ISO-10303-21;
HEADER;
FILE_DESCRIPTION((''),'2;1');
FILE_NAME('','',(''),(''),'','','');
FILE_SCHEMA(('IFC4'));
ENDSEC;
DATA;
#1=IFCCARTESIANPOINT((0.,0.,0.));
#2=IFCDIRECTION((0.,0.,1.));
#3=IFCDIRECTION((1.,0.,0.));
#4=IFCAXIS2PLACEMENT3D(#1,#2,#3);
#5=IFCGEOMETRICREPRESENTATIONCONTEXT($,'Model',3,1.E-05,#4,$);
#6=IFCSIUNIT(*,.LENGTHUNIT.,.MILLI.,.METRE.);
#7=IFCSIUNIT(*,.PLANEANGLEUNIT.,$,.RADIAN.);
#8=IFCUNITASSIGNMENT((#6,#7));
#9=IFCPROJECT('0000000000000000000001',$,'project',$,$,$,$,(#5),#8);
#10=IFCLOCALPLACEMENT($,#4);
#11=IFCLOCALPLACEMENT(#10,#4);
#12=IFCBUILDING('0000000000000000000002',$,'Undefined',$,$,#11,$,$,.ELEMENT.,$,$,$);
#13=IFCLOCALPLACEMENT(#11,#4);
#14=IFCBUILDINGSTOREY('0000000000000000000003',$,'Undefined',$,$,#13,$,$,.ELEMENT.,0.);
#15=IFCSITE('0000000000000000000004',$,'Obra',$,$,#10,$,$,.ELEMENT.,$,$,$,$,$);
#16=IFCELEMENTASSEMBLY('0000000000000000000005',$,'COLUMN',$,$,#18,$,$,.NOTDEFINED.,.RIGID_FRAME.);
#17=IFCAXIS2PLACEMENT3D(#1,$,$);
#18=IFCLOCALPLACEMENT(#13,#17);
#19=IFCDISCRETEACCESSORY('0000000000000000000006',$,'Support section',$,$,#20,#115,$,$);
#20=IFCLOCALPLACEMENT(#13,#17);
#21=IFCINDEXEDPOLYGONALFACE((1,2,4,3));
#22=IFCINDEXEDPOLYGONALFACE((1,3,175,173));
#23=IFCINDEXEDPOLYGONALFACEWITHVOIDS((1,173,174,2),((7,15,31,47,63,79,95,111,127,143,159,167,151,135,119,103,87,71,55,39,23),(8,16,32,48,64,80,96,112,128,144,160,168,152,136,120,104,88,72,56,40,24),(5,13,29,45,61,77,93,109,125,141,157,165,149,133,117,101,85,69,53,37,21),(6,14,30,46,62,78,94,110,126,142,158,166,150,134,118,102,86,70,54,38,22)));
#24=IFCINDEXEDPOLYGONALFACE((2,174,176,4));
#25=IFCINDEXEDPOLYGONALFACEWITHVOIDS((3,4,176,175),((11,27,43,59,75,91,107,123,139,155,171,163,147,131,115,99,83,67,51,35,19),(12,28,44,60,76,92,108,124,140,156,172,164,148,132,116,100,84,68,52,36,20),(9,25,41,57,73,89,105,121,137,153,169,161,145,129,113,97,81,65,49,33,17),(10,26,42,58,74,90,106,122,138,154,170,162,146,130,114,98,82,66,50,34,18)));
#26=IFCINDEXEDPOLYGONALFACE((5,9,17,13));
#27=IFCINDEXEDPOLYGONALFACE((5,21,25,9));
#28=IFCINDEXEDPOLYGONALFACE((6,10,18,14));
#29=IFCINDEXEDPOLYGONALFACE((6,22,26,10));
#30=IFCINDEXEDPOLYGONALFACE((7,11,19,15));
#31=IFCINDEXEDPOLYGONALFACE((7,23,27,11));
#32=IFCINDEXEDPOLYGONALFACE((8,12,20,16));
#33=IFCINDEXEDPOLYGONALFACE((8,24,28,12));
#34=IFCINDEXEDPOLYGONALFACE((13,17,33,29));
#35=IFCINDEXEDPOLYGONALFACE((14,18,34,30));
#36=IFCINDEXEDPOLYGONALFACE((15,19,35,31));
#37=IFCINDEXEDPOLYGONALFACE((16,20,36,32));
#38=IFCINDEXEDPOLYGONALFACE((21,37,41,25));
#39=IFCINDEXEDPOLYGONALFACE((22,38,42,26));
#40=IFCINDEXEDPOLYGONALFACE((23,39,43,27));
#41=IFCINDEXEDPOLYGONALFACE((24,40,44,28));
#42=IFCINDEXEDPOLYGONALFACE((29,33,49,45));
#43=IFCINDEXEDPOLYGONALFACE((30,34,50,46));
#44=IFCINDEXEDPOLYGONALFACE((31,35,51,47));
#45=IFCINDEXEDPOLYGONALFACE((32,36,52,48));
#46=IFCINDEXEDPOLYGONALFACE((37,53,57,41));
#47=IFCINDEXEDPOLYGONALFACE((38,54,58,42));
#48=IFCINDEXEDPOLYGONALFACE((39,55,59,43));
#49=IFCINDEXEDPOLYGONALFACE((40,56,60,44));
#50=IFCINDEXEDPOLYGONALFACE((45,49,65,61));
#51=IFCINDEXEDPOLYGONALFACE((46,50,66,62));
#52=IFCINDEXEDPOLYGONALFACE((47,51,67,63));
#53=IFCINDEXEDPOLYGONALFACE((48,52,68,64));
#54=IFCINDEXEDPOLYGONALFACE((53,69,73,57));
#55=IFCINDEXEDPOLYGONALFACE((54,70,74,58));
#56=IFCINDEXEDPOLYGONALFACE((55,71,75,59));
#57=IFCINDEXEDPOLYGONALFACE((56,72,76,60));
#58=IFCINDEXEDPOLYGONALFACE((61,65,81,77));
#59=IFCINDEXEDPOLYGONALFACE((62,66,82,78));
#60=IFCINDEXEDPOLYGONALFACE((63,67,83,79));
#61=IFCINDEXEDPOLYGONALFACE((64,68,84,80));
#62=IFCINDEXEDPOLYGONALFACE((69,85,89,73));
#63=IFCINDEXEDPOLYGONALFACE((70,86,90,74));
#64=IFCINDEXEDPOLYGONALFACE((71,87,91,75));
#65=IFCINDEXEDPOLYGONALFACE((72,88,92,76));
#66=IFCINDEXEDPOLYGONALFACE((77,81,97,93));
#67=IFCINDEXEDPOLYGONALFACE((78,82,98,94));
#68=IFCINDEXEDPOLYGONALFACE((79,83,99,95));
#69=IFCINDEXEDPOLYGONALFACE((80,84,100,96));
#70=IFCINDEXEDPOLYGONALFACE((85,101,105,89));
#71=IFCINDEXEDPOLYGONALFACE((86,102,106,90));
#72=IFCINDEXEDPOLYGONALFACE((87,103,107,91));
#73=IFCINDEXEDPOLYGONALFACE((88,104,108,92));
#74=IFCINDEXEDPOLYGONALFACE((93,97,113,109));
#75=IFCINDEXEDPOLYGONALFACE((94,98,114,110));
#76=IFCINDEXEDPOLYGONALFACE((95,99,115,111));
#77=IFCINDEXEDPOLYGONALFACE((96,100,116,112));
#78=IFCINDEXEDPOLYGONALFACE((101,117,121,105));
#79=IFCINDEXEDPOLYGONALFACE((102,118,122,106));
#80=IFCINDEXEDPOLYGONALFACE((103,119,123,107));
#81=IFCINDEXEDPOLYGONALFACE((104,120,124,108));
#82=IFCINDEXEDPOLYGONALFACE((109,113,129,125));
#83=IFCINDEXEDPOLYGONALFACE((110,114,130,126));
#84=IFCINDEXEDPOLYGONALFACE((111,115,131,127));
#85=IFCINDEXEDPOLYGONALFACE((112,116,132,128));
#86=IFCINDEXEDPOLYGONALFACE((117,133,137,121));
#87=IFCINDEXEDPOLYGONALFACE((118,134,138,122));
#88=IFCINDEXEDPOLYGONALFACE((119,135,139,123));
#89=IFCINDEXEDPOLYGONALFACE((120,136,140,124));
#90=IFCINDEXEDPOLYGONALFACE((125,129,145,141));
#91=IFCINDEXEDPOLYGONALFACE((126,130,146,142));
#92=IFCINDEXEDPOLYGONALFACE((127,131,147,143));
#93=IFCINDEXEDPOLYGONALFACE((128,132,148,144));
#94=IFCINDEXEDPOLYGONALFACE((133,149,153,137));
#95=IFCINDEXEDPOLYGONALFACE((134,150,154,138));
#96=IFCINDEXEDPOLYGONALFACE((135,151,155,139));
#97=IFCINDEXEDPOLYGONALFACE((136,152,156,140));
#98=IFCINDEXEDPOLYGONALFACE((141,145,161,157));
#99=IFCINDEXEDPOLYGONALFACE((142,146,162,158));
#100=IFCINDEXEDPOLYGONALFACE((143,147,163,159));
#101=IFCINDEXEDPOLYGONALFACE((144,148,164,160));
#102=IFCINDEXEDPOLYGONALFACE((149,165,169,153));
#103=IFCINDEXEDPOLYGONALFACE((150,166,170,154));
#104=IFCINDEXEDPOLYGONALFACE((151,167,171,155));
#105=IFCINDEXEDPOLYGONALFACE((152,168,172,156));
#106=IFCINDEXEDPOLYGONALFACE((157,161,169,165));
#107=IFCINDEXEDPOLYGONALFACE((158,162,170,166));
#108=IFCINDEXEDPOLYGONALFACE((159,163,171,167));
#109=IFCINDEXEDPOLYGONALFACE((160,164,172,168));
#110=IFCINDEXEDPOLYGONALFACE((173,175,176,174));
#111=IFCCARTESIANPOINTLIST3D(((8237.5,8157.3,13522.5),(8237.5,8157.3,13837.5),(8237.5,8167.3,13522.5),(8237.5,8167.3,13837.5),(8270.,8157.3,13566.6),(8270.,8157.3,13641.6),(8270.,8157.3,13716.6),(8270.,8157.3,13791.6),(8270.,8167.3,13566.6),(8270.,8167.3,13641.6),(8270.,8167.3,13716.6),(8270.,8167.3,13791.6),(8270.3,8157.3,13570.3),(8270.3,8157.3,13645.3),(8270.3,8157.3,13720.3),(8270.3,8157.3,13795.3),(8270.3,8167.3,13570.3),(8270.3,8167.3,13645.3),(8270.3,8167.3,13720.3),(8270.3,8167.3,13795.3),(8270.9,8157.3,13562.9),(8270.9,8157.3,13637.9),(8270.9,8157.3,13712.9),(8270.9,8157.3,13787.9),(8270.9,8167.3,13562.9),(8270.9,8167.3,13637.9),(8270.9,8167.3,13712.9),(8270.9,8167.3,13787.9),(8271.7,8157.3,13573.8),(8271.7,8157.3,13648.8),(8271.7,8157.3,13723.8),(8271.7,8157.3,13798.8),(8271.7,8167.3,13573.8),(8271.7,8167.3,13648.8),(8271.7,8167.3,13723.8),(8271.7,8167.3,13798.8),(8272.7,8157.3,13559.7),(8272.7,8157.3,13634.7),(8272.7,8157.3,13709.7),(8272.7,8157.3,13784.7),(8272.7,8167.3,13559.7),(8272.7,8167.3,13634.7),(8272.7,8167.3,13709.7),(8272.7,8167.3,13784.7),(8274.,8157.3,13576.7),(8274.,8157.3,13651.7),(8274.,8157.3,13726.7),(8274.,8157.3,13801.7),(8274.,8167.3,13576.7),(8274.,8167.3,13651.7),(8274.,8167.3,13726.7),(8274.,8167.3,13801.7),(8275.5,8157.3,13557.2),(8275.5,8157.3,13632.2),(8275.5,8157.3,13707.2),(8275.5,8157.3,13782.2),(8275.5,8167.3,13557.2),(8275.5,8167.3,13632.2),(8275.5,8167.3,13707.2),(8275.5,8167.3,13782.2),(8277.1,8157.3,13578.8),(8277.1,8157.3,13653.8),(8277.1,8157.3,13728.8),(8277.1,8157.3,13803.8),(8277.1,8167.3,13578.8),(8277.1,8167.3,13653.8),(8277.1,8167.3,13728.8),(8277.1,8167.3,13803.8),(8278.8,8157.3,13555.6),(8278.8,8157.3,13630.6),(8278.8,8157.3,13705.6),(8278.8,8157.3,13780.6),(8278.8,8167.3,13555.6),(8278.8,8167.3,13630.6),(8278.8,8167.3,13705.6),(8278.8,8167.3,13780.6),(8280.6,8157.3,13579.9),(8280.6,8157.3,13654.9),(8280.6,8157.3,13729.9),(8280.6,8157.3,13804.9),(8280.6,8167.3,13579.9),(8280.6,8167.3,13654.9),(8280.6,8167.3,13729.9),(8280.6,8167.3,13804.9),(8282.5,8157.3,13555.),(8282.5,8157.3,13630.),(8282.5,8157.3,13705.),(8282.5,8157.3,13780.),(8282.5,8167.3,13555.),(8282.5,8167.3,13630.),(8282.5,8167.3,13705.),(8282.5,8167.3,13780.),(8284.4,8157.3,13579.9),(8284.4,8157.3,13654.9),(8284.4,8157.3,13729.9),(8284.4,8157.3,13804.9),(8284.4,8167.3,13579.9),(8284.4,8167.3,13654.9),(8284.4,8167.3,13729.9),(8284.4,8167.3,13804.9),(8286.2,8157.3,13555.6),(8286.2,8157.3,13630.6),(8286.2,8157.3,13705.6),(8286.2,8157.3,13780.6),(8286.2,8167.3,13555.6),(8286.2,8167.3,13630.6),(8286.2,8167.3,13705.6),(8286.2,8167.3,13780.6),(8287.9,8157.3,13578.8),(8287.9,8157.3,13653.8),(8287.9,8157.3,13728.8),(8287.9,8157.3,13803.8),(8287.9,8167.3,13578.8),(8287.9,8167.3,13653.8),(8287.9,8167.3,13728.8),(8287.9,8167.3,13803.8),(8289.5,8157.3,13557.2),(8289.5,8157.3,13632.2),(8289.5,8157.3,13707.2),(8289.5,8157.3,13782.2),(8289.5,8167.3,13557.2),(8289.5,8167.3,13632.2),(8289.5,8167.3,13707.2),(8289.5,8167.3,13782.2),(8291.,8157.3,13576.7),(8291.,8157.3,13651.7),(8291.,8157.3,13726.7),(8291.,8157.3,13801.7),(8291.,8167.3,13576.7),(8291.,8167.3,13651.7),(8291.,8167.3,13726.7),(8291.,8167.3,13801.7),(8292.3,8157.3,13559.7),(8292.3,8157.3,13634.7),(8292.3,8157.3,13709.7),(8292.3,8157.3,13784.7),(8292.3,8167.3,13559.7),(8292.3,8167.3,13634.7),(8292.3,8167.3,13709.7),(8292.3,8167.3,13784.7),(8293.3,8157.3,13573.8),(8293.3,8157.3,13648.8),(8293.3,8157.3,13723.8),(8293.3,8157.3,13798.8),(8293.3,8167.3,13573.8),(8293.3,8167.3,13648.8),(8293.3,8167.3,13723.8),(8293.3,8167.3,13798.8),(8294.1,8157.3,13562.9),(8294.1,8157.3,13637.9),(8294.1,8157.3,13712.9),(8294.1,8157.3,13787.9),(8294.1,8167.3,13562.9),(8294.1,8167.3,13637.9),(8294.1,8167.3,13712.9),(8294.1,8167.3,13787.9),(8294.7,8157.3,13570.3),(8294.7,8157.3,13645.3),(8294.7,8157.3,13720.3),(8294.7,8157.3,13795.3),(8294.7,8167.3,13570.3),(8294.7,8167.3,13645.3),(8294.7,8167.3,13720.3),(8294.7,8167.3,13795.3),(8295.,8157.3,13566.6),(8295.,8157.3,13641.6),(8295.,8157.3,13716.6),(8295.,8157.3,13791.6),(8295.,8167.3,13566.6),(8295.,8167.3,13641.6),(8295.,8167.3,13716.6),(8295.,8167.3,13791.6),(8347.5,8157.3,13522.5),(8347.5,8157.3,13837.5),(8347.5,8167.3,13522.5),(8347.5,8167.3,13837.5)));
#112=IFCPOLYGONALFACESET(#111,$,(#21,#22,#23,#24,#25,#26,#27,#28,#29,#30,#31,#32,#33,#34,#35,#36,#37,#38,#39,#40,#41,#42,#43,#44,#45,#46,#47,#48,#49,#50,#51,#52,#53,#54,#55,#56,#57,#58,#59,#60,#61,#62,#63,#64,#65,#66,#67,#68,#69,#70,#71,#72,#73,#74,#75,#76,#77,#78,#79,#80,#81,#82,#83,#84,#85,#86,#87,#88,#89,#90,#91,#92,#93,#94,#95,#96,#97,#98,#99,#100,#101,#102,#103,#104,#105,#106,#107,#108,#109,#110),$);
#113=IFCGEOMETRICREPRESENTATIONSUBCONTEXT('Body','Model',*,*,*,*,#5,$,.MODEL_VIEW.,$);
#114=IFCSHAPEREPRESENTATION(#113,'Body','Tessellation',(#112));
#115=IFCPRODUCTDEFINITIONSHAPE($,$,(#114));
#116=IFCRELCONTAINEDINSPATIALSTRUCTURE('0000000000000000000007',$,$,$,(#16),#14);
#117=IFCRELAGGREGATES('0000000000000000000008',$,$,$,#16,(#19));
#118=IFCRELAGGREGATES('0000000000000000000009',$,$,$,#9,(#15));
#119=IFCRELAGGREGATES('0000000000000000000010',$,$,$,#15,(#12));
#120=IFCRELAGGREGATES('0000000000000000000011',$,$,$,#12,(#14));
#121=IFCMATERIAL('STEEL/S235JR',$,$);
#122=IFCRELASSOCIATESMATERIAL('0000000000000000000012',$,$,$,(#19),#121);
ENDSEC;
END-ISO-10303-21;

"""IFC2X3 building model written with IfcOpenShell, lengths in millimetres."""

from ifc_helpers import new_model, si_unit, frame, origin_with_axes, origin_2d_with_axis, place, context, subcontext, project, spatial, rectangle, circle, extrude, source, transform, mapped, material, element, aggregate, save


model = new_model("IFC2X3")

# Units and contexts
model_context = context("Model", 3, precision=1e-05, world=origin_with_axes())
body_context = subcontext(model_context, "Body", "Model", "MODEL_VIEW")
ifc_project = project(units=[si_unit("LENGTHUNIT", "METRE", prefix="MILLI"), si_unit("PLANEANGLEUNIT", "RADIAN")], contexts=[model_context])

# Site, building, storey
site_placement = place(None, origin_with_axes())
site = spatial("IfcSite", under=ifc_project, at=site_placement, Name="Obra", CompositionType="ELEMENT")
building_placement = place(site_placement, origin_with_axes())
building = spatial("IfcBuilding", under=site, at=building_placement, Name="Undefined", CompositionType="ELEMENT")
storey_placement = place(building_placement, origin_with_axes())
storey = spatial("IfcBuildingStorey", under=building, at=storey_placement, Name="Undefined", CompositionType="ELEMENT", Elevation=0.0)

# Element assembly
assembly_1_placement = place(storey_placement, origin_with_axes())
assembly_1 = element("IfcElementAssembly", 1, at=assembly_1_placement, inside=storey, Name="COLUMN", AssemblyPlace="NOTDEFINED", PredefinedType="RIGID_FRAME")
ifc_material_1 = material(Name="STEEL/S235JR")

# Discrete accessory, opening
discrete_accessory_1_placement = place(assembly_1_placement, frame((8292.5, 8162.3, 13522.5), z_axis=(0.0, 0.0, 1.0), x_axis=(1.0, 0.0, 0.0)))
discrete_accessory_1 = element("IfcDiscreteAccessory", 2, at=discrete_accessory_1_placement, material=ifc_material_1, Name="Support section", context=body_context, shape_type="SweptSolid", body=[
    extrude(rectangle(XDim=10.0, YDim=110.0, at=origin_2d_with_axis()), frame((0.0, 0.0, 315.0), z_axis=(0.0, 0.0, -1.0), x_axis=(0.0, 1.0, 0.0)), (0.0, 0.0, 1.0), 315.0),
])
shared_shape_1 = source(origin_with_axes(), body_context, "Body", "SweptSolid", [
    extrude(circle(Radius=12.5, at=origin_2d_with_axis()), frame((0.0, 5.7, 0.0), z_axis=(0.0, 1.0, 0.0), x_axis=(1.0, 0.0, 0.0)), (0.0, 0.0, 1.0), 10.2),
])
opening_1_placement = place(assembly_1_placement, frame((8327.5, 8173.1, 13900.0), z_axis=(-1.0, 0.0, 0.0), x_axis=(0.0, 0.0, -1.0)))
element("IfcOpeningElement", 3, at=opening_1_placement, cuts=discrete_accessory_1, ObjectType="Opening", context=body_context, shape_type="MappedRepresentation", body=[
    mapped(shared_shape_1, transform((107.5, 0.0, 45.0))),
    mapped(shared_shape_1, transform((182.5, 0.0, 45.0))),
    mapped(shared_shape_1, transform((257.5, 0.0, 45.0))),
    mapped(shared_shape_1, transform((332.5, 0.0, 45.0))),
])
aggregate(assembly_1, [discrete_accessory_1])

save(model, "model.ifc")
